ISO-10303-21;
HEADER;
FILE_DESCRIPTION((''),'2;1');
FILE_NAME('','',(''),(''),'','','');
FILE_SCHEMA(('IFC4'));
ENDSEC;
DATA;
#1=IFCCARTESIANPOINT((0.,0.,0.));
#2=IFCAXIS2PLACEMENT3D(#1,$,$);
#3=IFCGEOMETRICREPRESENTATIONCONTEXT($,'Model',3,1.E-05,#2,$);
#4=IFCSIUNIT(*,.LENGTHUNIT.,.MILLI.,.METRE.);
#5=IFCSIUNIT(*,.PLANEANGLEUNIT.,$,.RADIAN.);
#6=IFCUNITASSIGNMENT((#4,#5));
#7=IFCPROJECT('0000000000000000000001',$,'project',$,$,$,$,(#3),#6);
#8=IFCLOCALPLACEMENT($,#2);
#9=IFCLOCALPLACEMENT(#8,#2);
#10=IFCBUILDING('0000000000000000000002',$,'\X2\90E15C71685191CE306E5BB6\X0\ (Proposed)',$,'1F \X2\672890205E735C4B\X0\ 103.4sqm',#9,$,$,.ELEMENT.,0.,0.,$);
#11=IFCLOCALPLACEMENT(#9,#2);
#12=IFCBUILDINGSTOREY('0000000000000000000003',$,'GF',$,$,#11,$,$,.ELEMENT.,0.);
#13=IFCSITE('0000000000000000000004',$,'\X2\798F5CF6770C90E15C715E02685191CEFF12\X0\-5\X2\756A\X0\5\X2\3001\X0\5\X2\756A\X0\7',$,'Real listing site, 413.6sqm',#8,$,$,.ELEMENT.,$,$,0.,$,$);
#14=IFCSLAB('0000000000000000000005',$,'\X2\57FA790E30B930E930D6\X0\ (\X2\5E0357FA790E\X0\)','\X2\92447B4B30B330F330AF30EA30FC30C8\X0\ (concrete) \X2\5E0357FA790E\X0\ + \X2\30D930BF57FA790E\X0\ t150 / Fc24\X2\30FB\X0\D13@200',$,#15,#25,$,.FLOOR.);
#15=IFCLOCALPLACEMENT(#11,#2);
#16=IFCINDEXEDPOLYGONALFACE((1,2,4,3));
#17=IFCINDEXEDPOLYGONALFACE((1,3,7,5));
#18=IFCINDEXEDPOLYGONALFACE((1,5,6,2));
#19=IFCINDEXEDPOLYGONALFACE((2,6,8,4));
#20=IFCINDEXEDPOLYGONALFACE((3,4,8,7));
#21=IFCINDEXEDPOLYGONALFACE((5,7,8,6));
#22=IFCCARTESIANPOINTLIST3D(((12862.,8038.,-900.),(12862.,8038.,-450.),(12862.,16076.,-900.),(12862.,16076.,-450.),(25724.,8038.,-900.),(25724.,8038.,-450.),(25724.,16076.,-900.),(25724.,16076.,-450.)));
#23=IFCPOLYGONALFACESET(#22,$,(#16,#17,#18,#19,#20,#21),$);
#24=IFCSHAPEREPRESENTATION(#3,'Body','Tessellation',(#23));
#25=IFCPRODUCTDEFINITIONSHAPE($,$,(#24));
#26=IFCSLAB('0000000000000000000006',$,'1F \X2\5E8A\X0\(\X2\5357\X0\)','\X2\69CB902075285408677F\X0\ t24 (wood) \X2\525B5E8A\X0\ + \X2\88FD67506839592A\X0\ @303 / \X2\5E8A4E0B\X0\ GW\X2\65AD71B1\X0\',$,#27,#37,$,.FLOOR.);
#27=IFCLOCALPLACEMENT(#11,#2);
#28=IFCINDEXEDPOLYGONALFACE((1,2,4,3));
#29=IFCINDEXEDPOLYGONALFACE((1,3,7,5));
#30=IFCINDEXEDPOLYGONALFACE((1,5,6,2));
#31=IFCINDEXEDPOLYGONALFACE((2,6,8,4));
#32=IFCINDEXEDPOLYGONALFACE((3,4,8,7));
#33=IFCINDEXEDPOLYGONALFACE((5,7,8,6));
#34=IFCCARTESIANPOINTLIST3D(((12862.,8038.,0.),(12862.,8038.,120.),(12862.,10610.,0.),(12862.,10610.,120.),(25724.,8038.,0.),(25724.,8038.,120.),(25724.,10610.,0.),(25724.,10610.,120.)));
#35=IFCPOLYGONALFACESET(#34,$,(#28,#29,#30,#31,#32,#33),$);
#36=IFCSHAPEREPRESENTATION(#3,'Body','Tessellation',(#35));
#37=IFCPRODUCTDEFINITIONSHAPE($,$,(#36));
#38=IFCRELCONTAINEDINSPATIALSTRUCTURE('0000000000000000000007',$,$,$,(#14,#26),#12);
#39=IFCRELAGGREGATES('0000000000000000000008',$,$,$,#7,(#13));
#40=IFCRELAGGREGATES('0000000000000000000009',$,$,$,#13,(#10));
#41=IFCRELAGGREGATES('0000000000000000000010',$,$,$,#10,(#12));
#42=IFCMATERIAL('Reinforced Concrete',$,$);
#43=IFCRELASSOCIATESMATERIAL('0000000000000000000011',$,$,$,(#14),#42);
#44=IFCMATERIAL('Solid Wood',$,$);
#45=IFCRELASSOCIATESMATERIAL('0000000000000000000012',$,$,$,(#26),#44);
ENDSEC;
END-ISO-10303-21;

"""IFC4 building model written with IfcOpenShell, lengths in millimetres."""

from ifc_helpers import new_model, si_unit, frame, frame_2d, origin, place, context, project, spatial, rectangle, extrude, material, element, save


model = new_model("IFC4")

# Units and contexts
model_context = context("Model", 3, precision=1e-05, world=origin())
ifc_project = project(units=[si_unit("LENGTHUNIT", "METRE", prefix="MILLI"), si_unit("PLANEANGLEUNIT", "RADIAN")], contexts=[model_context])

# Site, building, storey
site_placement = place(None, origin())
site = spatial("IfcSite", under=ifc_project, at=site_placement, Name="福島県郡山市桑野２-5番5、5番7", ObjectType="Real listing site, 413.6sqm", CompositionType="ELEMENT", RefElevation=0.0)
building_placement = place(site_placement, origin())
building = spatial("IfcBuilding", under=site, at=building_placement, Name="郡山桑野の家 (Proposed)", ObjectType="1F 木造平屋 103.4sqm", CompositionType="ELEMENT", ElevationOfRefHeight=0.0, ElevationOfTerrain=0.0)
storey_placement = place(building_placement, origin())
storey = spatial("IfcBuildingStorey", under=building, at=storey_placement, Name="GF", CompositionType="ELEMENT", Elevation=0.0)

# Slabs
ifc_material_1 = material(Name="Reinforced Concrete")
slab_1_placement = place(storey_placement, frame((6431.0, 4019.0, -450.0)))
element("IfcSlab", 1, at=slab_1_placement, inside=storey, material=ifc_material_1, Name="基礎スラブ (布基礎)", Description="鉄筋コンクリート (concrete) 布基礎 + ベタ基礎 t150 / Fc24・D13@200", PredefinedType="FLOOR", context=model_context, shape_type="SweptSolid", body=[
    extrude(rectangle(XDim=12862.0, YDim=8038.0, at=frame_2d((6431.0, 4019.0))), frame((6431.0, 4019.0, -450.0)), (0.0, 0.0, 1.0), 450.0),
])
ifc_material_2 = material(Name="Solid Wood")
slab_2_placement = place(storey_placement, frame((6431.0, 4019.0, 0.0)))
element("IfcSlab", 2, at=slab_2_placement, inside=storey, material=ifc_material_2, Name="1F 床(南)", Description="構造用合板 t24 (wood) 剛床 + 製材根太 @303 / 床下 GW断熱", PredefinedType="FLOOR", context=model_context, shape_type="SweptSolid", body=[
    extrude(rectangle(XDim=12862.0, YDim=2572.0, at=frame_2d((6431.0, 1286.0))), frame((6431.0, 4019.0, 0.0)), (0.0, 0.0, 1.0), 120.0),
])

save(model, "model.ifc")
